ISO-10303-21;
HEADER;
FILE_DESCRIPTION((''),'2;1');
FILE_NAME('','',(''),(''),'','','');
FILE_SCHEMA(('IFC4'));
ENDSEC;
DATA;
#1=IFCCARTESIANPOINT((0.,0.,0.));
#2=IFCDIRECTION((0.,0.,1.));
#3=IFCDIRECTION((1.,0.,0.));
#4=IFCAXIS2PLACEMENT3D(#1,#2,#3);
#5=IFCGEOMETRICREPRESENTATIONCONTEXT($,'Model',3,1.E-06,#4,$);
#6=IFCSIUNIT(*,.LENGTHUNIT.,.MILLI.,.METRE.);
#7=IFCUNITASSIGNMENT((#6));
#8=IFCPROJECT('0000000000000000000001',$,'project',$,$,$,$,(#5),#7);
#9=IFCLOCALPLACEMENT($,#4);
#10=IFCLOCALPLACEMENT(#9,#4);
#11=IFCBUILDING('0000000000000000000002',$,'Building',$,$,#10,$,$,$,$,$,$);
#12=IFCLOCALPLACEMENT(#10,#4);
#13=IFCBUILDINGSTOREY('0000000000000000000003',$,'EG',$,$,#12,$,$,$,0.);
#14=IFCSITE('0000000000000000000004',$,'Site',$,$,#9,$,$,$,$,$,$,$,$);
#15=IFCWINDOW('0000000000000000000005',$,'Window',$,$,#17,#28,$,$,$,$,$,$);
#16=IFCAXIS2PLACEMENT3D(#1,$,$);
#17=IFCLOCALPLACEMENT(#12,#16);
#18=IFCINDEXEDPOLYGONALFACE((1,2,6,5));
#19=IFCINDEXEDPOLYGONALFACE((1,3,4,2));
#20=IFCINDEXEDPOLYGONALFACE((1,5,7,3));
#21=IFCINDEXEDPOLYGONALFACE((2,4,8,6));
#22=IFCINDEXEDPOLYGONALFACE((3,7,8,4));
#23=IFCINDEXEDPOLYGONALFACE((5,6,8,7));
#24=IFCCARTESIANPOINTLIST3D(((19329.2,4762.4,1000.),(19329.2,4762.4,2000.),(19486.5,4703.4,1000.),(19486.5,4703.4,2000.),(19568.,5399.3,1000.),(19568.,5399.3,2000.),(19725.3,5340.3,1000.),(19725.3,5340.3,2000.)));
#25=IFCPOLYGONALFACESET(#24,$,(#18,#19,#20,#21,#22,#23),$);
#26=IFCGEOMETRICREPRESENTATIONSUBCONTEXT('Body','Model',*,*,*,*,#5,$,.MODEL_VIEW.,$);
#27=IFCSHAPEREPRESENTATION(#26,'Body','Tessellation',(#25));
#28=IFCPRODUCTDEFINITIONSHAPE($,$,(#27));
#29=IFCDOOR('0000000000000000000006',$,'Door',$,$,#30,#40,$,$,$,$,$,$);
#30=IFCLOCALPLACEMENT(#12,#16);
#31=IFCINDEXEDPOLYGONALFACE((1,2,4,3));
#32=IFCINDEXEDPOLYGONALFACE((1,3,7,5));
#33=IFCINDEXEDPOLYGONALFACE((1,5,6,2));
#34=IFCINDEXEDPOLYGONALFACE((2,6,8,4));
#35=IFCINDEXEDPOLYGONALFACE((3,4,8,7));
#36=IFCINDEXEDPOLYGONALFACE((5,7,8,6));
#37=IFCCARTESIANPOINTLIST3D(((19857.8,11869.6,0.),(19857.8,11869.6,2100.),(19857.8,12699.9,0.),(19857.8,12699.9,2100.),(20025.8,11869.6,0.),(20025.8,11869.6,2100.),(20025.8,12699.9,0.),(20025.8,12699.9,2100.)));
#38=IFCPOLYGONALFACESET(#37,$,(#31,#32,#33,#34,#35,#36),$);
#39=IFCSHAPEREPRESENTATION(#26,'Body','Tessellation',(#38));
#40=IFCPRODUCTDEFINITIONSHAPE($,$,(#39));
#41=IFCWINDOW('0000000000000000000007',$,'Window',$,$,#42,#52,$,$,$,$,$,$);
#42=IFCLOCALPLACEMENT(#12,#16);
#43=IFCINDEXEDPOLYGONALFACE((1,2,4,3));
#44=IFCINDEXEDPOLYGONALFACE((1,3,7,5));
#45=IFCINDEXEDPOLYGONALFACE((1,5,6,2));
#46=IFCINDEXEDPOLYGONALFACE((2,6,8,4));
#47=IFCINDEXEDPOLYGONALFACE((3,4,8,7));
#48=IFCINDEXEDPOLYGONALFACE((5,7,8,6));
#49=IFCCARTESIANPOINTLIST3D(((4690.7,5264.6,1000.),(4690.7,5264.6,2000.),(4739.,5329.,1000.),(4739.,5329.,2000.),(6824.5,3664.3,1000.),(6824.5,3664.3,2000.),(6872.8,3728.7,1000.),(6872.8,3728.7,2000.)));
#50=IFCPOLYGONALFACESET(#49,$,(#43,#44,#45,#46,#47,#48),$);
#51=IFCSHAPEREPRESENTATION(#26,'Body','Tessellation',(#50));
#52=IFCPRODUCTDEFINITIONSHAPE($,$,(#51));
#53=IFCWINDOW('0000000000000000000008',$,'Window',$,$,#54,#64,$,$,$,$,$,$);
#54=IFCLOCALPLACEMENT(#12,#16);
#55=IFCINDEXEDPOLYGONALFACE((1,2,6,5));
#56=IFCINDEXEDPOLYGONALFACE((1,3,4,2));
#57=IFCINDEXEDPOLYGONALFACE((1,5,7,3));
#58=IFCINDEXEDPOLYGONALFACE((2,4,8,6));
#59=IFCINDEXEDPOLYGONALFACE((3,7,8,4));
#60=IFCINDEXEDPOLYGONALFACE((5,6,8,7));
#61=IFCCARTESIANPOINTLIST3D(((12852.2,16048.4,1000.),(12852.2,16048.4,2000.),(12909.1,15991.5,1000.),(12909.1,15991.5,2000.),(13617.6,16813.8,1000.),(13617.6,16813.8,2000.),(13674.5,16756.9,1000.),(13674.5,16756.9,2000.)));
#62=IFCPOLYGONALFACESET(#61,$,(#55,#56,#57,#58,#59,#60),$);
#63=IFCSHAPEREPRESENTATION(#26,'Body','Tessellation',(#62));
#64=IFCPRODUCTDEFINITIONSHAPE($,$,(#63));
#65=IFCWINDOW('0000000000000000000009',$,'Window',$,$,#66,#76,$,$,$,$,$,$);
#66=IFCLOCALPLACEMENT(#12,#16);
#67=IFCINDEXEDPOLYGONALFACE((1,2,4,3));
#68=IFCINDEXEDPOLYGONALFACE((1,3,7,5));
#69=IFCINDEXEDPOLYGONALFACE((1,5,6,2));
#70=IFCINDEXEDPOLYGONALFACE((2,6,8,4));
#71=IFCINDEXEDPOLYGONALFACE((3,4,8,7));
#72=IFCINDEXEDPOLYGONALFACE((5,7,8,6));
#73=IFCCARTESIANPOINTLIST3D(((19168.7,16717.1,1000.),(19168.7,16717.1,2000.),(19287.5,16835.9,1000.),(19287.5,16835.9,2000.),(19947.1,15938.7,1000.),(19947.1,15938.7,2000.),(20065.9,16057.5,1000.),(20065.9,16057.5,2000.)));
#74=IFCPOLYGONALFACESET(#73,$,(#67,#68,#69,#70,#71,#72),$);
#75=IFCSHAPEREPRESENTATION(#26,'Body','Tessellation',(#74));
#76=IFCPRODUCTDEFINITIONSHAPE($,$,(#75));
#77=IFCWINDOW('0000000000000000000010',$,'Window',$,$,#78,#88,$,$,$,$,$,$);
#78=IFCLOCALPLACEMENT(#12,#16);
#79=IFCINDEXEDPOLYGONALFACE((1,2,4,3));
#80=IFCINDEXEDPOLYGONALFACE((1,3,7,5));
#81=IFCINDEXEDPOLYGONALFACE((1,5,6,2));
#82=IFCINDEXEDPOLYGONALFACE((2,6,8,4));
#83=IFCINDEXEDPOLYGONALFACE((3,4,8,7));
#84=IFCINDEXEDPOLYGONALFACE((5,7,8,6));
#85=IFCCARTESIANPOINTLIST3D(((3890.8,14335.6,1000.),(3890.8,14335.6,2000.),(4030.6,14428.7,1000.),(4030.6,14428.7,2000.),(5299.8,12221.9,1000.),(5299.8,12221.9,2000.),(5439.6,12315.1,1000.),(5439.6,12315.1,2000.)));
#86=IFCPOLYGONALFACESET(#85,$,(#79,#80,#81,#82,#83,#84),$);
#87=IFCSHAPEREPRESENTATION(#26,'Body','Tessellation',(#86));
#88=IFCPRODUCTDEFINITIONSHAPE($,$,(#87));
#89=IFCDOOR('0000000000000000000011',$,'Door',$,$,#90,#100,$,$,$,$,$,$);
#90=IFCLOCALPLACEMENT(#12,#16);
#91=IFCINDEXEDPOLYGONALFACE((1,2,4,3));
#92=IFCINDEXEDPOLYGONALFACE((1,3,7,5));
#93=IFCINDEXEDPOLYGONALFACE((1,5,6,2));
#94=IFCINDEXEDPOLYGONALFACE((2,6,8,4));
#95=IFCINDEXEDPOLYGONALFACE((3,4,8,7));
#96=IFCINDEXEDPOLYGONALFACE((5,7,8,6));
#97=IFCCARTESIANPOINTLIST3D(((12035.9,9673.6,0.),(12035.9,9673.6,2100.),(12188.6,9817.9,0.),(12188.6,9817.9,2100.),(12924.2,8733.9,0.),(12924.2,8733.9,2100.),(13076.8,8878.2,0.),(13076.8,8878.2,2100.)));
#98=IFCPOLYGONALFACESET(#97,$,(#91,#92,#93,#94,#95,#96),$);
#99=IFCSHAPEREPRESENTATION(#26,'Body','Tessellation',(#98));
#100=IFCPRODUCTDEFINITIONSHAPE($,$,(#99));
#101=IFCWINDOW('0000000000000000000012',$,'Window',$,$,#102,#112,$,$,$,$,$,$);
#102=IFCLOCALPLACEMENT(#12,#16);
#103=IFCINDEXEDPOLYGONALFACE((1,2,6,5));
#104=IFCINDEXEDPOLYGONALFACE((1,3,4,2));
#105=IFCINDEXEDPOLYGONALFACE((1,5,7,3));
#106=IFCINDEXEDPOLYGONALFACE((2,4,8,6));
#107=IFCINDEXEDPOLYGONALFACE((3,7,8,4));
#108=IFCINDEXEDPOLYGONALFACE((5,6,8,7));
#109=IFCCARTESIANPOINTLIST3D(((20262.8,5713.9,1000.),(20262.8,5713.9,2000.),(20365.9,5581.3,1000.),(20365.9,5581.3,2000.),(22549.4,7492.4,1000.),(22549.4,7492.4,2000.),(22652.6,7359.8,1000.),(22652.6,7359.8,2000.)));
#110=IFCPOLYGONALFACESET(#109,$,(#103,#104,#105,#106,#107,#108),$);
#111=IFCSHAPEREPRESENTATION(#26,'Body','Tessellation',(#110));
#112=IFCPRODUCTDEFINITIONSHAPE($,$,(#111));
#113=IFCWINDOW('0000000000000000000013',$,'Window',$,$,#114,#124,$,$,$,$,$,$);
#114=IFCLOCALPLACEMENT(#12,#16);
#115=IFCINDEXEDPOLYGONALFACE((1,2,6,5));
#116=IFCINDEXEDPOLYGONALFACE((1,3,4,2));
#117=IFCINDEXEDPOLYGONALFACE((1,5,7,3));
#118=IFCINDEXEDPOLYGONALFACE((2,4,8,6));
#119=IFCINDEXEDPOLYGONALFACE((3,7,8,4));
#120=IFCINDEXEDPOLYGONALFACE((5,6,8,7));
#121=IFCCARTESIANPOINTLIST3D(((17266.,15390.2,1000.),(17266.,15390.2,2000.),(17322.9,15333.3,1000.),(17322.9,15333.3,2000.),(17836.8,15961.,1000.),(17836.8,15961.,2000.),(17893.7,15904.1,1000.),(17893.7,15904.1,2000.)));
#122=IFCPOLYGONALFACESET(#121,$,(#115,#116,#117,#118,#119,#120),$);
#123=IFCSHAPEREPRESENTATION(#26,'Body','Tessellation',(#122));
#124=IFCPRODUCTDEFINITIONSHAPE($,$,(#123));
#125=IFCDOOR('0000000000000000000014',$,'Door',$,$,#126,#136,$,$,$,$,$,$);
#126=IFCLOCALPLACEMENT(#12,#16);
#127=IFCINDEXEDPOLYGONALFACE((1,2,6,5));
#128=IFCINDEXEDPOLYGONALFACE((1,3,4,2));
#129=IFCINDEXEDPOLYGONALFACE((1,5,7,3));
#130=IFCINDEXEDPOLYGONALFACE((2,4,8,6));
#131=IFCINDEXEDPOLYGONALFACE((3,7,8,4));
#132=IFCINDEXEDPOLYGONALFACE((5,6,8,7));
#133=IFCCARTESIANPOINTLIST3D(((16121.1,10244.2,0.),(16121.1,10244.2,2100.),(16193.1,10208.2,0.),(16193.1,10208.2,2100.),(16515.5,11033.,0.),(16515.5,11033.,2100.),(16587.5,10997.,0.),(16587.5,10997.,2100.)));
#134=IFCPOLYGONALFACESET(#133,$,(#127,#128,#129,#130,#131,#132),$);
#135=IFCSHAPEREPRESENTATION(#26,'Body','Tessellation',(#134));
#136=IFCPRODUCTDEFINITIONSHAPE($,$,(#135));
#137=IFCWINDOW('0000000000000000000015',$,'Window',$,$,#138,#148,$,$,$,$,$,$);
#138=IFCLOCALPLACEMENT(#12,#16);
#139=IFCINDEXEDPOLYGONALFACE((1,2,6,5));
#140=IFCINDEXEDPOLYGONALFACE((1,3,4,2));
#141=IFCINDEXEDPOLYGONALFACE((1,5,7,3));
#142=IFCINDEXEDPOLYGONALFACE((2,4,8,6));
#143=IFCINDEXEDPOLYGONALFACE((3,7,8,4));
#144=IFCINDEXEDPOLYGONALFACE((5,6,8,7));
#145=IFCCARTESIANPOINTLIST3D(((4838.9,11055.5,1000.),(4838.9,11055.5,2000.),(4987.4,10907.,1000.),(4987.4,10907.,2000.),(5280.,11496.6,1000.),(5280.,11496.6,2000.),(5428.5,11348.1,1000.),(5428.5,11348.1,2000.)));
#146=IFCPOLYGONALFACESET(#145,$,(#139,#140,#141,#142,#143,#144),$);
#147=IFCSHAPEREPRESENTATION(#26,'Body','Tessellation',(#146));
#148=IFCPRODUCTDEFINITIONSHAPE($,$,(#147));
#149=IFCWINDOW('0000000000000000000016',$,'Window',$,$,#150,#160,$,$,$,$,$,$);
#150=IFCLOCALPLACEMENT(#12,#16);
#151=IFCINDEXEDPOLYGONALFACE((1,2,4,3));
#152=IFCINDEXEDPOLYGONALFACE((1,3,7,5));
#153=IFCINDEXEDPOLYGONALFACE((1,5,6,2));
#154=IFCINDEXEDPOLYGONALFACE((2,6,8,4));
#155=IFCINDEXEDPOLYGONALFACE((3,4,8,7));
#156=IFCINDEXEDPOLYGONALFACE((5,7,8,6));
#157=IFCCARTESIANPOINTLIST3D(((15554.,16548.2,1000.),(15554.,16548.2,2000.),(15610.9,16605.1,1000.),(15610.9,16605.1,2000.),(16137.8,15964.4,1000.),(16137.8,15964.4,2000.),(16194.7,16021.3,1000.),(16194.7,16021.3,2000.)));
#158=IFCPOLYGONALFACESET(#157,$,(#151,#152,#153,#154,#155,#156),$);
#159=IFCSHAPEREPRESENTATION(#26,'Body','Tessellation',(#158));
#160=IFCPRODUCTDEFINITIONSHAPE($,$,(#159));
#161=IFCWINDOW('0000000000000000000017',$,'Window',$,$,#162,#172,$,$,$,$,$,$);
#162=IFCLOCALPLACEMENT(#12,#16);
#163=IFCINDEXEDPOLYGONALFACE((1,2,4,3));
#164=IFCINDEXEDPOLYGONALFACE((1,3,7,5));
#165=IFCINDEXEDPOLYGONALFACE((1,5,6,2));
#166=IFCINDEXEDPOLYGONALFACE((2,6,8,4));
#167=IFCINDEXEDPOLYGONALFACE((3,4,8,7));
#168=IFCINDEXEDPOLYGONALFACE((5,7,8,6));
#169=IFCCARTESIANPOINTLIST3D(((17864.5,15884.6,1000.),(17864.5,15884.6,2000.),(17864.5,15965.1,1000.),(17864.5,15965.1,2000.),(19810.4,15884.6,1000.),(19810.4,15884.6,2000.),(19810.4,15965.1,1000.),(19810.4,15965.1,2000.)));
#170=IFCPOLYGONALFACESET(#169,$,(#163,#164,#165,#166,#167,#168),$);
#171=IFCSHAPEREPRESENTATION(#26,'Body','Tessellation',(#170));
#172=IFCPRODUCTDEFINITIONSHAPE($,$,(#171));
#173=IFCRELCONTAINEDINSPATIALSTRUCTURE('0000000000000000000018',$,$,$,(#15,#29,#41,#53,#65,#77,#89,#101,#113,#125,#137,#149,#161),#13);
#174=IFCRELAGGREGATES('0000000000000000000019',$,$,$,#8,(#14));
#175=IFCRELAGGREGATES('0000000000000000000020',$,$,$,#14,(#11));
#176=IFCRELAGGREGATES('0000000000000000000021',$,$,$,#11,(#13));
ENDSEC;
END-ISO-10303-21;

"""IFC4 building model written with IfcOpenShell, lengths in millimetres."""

from ifc_helpers import new_model, si_unit, frame, origin_with_axes, place, context, subcontext, project, spatial, rectangle, extrude, element, save


model = new_model("IFC4")

# Units and contexts
model_context = context("Model", 3, precision=1e-06, world=origin_with_axes())
body_context = subcontext(model_context, "Body", "Model", "MODEL_VIEW")
ifc_project = project(units=[si_unit("LENGTHUNIT", "METRE", prefix="MILLI")], contexts=[model_context])

# Site, building, storey
site_placement = place(None, origin_with_axes())
site = spatial("IfcSite", under=ifc_project, at=site_placement, Name="Site")
building_placement = place(site_placement, origin_with_axes())
building = spatial("IfcBuilding", under=site, at=building_placement, Name="Building")
storey_placement = place(building_placement, origin_with_axes())
storey = spatial("IfcBuildingStorey", under=building, at=storey_placement, Name="EG", Elevation=0.0)

# Window
window_1_placement = place(storey_placement, origin_with_axes())
element("IfcWindow", 1, at=window_1_placement, inside=storey, Name="Window", context=body_context, shape_type="SweptSolid", body=[
    extrude(rectangle(XDim=680.2, YDim=168.0), frame((19527.2, 5051.4, 1000.0), z_axis=(0.0, 0.0, 1.0), x_axis=(0.351123, 0.936329, 0.0)), (0.0, 0.0, 1.0), 1000.0),
])

# Door
door_1_placement = place(storey_placement, origin_with_axes())
element("IfcDoor", 2, at=door_1_placement, inside=storey, Name="Door", context=body_context, shape_type="SweptSolid", body=[
    extrude(rectangle(XDim=830.3, YDim=168.0), frame((19941.8, 12284.7, 0.0), z_axis=(0.0, 0.0, 1.0), x_axis=(0.0, -1.0, 0.0)), (0.0, 0.0, 1.0), 2100.0),
])

# Windows
window_2_placement = place(storey_placement, origin_with_axes())
element("IfcWindow", 3, at=window_2_placement, inside=storey, Name="Window", context=body_context, shape_type="SweptSolid", body=[
    extrude(rectangle(XDim=2667.3, YDim=80.5), frame((5781.8, 4496.6, 1000.0), z_axis=(0.0, 0.0, 1.0), x_axis=(0.8, -0.6, 0.0)), (0.0, 0.0, 1.0), 1000.0),
])
window_3_placement = place(storey_placement, origin_with_axes())
element("IfcWindow", 4, at=window_3_placement, inside=storey, Name="Window", context=body_context, shape_type="SweptSolid", body=[
    extrude(rectangle(XDim=1082.5, YDim=80.5), frame((13263.3, 16402.7, 1000.0), z_axis=(0.0, 0.0, 1.0), x_axis=(0.707107, 0.707107, 0.0)), (0.0, 0.0, 1.0), 1000.0),
])
window_4_placement = place(storey_placement, origin_with_axes())
element("IfcWindow", 5, at=window_4_placement, inside=storey, Name="Window", context=body_context, shape_type="SweptSolid", body=[
    extrude(rectangle(XDim=1100.8, YDim=168.0), frame((19617.3, 16387.3, 1000.0), z_axis=(0.0, 0.0, 1.0), x_axis=(-0.707107, 0.707107, 0.0)), (0.0, 0.0, 1.0), 1000.0),
])
window_5_placement = place(storey_placement, origin_with_axes())
element("IfcWindow", 6, at=window_5_placement, inside=storey, Name="Window", context=body_context, shape_type="SweptSolid", body=[
    extrude(rectangle(XDim=2540.3, YDim=168.0), frame((4665.2, 13325.3, 1000.0), z_axis=(0.0, 0.0, 1.0), x_axis=(-0.5547, 0.83205, 0.0)), (0.0, 0.0, 1.0), 1000.0),
])

# Door
door_2_placement = place(storey_placement, origin_with_axes())
element("IfcDoor", 7, at=door_2_placement, inside=storey, Name="Door", context=body_context, shape_type="SweptSolid", body=[
    extrude(rectangle(XDim=1293.1, YDim=210.0), frame((12556.4, 9275.9, 0.0), z_axis=(0.0, 0.0, 1.0), x_axis=(0.686906, -0.726747, 0.0)), (0.0, 0.0, 1.0), 2100.0),
])

# Windows
window_6_placement = place(storey_placement, origin_with_axes())
element("IfcWindow", 8, at=window_6_placement, inside=storey, Name="Window", context=body_context, shape_type="SweptSolid", body=[
    extrude(rectangle(XDim=2896.9, YDim=168.0), frame((21457.7, 6536.9, 1000.0), z_axis=(0.0, 0.0, 1.0), x_axis=(-0.789352, -0.613941, 0.0)), (0.0, 0.0, 1.0), 1000.0),
])
window_7_placement = place(storey_placement, origin_with_axes())
element("IfcWindow", 9, at=window_7_placement, inside=storey, Name="Window", context=body_context, shape_type="SweptSolid", body=[
    extrude(rectangle(XDim=807.3, YDim=80.5), frame((17579.9, 15647.1, 1000.0), z_axis=(0.0, 0.0, 1.0), x_axis=(-0.707107, -0.707107, 0.0)), (0.0, 0.0, 1.0), 1000.0),
])

# Door
door_3_placement = place(storey_placement, origin_with_axes())
element("IfcDoor", 10, at=door_3_placement, inside=storey, Name="Door", context=body_context, shape_type="SweptSolid", body=[
    extrude(rectangle(XDim=881.9, YDim=80.5), frame((16354.3, 10620.6, 0.0), z_axis=(0.0, 0.0, 1.0), x_axis=(0.447214, 0.894427, 0.0)), (0.0, 0.0, 1.0), 2100.0),
])

# Windows
window_8_placement = place(storey_placement, origin_with_axes())
element("IfcWindow", 11, at=window_8_placement, inside=storey, Name="Window", context=body_context, shape_type="SweptSolid", body=[
    extrude(rectangle(XDim=623.8, YDim=210.0), frame((5133.7, 11201.8, 1000.0), z_axis=(0.0, 0.0, 1.0), x_axis=(-0.707107, -0.707107, 0.0)), (0.0, 0.0, 1.0), 1000.0),
])
window_9_placement = place(storey_placement, origin_with_axes())
element("IfcWindow", 12, at=window_9_placement, inside=storey, Name="Window", context=body_context, shape_type="SweptSolid", body=[
    extrude(rectangle(XDim=825.6, YDim=80.5), frame((15874.4, 16284.7, 1000.0), z_axis=(0.0, 0.0, 1.0), x_axis=(-0.707107, 0.707107, 0.0)), (0.0, 0.0, 1.0), 1000.0),
])
window_10_placement = place(storey_placement, origin_with_axes())
element("IfcWindow", 13, at=window_10_placement, inside=storey, Name="Window", context=body_context, shape_type="SweptSolid", body=[
    extrude(rectangle(XDim=1946.0, YDim=80.5), frame((18837.5, 15924.8, 1000.0), z_axis=(0.0, 0.0, 1.0), x_axis=(1.0, 0.0, 0.0)), (0.0, 0.0, 1.0), 1000.0),
])

save(model, "model.ifc")
